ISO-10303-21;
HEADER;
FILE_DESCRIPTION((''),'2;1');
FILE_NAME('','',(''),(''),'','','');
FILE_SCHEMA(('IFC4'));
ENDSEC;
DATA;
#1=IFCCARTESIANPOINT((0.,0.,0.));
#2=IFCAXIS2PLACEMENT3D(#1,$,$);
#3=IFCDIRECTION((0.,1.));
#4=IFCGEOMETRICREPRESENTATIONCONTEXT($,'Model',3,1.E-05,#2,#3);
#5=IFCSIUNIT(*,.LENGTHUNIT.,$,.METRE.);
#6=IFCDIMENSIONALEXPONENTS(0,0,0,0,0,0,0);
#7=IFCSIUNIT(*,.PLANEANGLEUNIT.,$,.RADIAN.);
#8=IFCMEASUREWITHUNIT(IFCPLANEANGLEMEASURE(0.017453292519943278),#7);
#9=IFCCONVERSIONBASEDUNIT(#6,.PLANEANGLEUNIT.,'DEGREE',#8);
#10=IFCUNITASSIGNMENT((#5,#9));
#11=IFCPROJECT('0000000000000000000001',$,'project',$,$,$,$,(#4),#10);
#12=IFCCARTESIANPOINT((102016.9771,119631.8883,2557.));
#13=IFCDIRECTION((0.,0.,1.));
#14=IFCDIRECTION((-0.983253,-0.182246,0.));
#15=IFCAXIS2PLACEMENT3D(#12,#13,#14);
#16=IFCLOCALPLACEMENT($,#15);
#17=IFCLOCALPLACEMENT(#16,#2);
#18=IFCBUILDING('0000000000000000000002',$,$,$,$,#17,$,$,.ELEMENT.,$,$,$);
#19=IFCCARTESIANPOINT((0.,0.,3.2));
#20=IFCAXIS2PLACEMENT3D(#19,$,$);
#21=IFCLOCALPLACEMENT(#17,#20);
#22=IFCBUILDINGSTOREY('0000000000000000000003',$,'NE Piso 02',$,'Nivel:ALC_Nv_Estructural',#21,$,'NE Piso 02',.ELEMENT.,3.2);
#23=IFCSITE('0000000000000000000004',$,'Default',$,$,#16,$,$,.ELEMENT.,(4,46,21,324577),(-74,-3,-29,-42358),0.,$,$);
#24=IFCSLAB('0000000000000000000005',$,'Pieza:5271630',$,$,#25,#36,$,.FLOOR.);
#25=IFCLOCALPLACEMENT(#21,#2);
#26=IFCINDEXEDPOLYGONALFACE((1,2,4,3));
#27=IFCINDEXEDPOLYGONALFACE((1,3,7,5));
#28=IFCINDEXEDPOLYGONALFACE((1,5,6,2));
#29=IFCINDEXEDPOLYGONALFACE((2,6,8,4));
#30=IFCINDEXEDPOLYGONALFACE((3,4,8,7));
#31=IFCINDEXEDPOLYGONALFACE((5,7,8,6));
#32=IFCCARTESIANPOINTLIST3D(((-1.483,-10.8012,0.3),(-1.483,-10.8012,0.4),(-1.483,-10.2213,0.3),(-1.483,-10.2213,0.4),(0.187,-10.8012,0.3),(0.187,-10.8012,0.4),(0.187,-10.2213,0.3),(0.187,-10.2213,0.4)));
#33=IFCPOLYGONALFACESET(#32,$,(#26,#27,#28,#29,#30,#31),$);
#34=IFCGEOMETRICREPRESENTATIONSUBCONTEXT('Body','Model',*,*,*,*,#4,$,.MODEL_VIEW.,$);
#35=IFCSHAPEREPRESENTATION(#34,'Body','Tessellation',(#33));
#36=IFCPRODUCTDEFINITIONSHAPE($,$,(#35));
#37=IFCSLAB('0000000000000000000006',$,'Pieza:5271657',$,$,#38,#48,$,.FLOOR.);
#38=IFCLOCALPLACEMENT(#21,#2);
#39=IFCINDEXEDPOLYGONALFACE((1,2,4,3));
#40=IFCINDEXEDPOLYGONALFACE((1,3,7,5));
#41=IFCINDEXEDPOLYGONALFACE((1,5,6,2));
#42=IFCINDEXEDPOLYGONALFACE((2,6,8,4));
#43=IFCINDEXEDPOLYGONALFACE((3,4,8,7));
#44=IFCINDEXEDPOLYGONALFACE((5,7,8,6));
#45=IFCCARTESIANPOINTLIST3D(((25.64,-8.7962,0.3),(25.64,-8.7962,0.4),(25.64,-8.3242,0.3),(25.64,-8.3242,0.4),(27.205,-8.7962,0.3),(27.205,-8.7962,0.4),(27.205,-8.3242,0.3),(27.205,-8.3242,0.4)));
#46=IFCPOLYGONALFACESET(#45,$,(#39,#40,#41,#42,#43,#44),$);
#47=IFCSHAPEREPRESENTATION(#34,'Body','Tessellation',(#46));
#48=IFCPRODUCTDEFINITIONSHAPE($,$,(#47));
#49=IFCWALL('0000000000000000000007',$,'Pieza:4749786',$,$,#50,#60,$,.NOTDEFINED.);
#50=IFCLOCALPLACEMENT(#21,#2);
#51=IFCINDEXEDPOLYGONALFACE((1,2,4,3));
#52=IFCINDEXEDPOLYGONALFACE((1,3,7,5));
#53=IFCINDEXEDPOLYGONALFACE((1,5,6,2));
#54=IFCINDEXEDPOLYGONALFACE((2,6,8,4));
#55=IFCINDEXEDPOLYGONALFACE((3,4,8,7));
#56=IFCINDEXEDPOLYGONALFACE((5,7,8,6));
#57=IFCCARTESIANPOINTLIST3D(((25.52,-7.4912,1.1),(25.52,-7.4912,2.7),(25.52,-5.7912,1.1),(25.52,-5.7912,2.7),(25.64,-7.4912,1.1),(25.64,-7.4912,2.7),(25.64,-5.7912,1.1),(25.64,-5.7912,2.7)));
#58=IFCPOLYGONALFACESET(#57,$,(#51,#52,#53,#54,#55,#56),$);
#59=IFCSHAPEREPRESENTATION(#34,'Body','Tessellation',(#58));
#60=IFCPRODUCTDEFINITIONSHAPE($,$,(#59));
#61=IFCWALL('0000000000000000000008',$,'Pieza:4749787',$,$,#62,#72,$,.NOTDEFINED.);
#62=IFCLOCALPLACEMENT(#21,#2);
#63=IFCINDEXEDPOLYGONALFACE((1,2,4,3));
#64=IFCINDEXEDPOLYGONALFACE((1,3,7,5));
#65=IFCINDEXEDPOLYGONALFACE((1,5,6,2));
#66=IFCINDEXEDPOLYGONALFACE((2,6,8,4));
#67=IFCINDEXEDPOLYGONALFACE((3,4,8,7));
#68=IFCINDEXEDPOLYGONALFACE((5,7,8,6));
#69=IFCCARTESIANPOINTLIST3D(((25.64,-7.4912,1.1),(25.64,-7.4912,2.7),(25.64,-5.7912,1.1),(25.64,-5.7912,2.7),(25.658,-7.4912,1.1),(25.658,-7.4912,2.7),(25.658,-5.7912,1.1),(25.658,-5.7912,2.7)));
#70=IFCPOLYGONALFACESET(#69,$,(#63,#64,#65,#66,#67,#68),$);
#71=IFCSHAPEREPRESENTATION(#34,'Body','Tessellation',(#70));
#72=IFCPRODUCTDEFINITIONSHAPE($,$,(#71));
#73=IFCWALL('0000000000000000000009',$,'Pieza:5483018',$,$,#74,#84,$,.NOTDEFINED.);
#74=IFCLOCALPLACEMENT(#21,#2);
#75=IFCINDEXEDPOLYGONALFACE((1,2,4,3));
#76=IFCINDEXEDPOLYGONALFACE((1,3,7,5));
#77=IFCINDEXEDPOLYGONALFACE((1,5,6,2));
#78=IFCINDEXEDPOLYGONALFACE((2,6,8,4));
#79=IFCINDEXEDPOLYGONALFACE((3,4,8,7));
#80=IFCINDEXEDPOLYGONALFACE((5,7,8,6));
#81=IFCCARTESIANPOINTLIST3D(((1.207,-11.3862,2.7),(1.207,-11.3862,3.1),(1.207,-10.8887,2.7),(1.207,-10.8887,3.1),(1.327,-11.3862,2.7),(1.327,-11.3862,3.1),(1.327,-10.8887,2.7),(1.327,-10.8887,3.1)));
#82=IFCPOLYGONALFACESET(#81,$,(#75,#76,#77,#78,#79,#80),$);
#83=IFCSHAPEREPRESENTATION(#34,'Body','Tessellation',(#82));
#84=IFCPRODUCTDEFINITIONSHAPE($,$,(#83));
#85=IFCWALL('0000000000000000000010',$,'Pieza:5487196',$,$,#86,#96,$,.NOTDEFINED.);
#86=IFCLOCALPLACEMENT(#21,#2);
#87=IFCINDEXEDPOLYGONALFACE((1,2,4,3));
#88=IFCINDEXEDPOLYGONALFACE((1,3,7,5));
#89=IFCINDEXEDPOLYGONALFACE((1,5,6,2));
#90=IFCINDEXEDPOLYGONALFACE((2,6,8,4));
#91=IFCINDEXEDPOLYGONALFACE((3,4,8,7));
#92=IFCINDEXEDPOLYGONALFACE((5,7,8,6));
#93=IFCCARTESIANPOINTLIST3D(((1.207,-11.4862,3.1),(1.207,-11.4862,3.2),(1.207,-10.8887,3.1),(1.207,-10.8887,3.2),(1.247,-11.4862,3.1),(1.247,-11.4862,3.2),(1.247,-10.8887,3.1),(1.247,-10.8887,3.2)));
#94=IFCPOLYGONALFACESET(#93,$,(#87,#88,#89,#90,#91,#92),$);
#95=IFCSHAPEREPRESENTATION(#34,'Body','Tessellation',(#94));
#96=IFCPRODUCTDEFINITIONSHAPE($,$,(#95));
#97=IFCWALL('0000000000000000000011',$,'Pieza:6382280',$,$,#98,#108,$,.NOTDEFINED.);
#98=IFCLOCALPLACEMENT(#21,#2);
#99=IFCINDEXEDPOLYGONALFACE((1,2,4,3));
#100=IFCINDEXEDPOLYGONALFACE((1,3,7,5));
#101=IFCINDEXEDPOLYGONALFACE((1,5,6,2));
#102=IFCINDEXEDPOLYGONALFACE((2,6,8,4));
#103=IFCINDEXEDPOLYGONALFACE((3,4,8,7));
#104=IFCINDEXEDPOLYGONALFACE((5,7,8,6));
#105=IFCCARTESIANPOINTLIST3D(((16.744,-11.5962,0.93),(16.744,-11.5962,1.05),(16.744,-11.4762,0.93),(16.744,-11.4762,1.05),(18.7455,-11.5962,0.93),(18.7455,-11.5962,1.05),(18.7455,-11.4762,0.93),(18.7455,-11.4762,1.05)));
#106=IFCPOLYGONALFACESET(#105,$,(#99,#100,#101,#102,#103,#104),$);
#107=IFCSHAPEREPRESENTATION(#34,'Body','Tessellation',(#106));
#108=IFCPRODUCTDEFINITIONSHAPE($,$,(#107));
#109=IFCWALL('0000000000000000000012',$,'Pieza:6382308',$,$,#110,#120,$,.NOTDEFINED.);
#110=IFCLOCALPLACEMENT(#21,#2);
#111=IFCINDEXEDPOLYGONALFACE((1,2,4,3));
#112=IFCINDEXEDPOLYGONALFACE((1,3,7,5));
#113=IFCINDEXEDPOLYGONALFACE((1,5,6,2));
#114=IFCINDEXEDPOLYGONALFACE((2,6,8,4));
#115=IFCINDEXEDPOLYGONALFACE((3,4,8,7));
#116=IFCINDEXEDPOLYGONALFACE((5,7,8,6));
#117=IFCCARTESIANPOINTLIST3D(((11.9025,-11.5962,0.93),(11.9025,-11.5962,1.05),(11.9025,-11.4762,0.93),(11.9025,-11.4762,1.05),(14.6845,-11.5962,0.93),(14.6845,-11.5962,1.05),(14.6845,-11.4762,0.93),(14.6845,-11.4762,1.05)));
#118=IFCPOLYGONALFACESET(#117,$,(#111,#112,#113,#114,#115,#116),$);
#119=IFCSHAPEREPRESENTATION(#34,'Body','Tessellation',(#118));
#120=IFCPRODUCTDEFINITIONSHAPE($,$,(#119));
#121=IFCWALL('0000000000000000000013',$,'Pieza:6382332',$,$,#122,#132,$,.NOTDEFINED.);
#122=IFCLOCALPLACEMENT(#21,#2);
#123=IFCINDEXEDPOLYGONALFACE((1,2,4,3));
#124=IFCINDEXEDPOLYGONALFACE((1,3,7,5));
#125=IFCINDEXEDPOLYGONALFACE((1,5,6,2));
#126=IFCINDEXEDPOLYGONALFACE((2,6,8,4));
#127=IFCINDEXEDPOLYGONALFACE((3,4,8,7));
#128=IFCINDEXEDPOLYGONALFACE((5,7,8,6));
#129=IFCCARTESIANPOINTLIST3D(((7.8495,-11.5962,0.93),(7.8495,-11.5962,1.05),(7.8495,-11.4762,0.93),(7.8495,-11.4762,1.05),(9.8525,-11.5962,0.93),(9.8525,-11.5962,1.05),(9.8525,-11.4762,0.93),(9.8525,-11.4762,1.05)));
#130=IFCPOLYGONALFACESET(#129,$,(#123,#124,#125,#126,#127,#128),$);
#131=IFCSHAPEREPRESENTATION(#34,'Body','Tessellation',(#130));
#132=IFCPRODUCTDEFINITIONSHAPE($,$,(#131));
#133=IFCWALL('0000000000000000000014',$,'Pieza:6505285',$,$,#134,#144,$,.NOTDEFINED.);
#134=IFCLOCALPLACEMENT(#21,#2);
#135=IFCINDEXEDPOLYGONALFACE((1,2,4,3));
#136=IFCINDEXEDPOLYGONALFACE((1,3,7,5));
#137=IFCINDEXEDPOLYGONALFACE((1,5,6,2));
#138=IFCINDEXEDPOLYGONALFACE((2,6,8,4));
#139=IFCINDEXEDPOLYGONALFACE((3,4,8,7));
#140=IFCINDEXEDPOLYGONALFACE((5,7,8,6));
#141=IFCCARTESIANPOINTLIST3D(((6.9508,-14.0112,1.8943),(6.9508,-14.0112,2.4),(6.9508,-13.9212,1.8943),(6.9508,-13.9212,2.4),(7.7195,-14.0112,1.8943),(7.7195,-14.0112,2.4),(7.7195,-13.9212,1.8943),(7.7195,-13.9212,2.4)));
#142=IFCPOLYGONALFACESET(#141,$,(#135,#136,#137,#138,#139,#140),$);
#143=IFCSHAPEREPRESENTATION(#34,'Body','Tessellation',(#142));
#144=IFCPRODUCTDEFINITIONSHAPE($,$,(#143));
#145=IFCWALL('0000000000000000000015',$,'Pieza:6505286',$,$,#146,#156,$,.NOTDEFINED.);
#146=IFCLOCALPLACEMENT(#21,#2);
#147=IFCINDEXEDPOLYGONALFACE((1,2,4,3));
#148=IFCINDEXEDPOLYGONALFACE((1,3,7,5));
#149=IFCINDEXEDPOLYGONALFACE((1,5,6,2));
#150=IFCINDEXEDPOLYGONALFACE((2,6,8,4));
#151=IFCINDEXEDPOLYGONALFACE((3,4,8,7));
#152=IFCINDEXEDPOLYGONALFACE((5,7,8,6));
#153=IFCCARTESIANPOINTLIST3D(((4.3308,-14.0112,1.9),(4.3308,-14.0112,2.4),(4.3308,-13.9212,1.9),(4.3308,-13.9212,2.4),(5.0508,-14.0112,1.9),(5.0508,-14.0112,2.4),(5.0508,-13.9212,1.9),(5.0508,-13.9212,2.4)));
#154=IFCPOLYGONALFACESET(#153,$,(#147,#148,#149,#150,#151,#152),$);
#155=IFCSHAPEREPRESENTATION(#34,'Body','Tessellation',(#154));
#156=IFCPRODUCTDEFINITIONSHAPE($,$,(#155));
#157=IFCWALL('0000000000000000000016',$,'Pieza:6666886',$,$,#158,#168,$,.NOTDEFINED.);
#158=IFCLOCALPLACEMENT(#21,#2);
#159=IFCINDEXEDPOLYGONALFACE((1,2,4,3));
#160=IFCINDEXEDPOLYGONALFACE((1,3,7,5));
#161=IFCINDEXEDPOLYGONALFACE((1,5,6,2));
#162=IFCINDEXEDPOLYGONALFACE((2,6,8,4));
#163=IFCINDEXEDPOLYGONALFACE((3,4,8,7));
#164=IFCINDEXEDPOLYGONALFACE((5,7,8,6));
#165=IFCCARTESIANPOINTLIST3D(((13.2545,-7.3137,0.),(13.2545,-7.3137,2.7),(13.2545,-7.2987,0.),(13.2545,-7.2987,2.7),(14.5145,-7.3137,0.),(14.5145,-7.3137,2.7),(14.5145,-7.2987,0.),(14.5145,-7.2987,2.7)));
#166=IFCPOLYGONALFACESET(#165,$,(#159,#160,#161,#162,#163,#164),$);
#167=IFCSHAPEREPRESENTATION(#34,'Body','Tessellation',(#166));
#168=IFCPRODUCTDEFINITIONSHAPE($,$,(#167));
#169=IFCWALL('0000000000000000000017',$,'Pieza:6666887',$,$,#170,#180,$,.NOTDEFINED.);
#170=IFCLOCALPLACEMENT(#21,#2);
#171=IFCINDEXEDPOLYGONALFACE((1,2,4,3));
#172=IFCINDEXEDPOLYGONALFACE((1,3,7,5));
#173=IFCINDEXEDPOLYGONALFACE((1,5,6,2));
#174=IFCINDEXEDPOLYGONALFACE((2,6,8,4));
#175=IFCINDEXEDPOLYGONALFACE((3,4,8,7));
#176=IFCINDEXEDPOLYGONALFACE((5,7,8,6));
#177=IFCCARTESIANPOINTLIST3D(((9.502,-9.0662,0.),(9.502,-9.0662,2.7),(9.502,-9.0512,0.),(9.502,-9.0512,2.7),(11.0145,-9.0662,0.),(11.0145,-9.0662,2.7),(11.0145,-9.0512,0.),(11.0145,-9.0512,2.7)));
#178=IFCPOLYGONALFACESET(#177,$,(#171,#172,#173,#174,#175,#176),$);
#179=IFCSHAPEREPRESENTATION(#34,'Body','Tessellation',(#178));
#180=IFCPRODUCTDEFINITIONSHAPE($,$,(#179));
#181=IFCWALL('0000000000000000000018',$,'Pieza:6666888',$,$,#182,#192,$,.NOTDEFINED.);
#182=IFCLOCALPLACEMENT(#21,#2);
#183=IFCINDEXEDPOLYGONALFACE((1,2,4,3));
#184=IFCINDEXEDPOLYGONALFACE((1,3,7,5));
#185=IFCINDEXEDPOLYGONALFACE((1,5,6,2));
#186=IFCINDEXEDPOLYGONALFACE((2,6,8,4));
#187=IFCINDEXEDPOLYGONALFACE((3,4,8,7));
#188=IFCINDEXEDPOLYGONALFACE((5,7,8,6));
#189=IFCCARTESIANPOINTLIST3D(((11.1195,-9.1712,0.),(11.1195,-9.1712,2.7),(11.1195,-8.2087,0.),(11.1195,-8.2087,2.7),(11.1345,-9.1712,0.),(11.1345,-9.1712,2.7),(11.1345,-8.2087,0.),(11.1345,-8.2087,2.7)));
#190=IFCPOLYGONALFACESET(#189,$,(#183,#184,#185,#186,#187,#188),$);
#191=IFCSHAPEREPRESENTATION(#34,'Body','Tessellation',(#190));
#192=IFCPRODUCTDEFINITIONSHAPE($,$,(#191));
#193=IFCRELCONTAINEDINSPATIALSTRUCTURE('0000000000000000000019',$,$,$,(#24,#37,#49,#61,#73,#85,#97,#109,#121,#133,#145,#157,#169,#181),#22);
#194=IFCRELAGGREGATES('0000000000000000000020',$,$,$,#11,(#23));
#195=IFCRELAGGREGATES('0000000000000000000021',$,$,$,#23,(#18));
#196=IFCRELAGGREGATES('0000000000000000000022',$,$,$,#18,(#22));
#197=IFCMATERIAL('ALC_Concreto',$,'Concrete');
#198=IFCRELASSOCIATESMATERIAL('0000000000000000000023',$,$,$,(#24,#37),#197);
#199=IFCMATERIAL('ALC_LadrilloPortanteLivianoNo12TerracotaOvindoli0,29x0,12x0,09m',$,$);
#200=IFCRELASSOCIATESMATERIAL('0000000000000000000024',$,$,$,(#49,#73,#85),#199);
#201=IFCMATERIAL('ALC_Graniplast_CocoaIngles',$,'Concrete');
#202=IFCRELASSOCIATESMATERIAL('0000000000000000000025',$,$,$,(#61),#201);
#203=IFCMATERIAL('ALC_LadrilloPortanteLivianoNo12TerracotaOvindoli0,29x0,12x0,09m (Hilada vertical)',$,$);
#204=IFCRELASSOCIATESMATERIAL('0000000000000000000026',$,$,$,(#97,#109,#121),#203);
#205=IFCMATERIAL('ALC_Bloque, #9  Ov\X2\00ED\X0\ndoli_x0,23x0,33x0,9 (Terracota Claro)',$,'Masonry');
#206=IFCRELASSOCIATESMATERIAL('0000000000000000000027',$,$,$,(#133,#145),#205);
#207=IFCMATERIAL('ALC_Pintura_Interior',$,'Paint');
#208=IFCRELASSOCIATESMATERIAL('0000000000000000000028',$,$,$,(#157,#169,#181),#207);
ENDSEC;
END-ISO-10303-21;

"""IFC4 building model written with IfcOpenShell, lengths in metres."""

from ifc_helpers import new_model, entity, si_unit, converted_unit, direction, frame, frame_2d, origin, origin_2d_with_axis, place, context, subcontext, project, spatial, rectangle, extrude, material, element, save


model = new_model("IFC4")

# Units and contexts
model_context = context("Model", 3, precision=1e-05, world=origin(), true_north=direction((0.0, 1.0)))
body_context = subcontext(model_context, "Body", "Model", "MODEL_VIEW")
ifc_project = project(units=[si_unit("LENGTHUNIT", "METRE"), converted_unit("PLANEANGLEUNIT", "DEGREE", entity("IfcPlaneAngleMeasure", 0.017453292519943278), si_unit("PLANEANGLEUNIT", "RADIAN"), dimensions=[0, 0, 0, 0, 0, 0, 0])], contexts=[model_context])

# Site, building, storey
site_placement = place(None, frame((102016.9771, 119631.8883, 2557.0), z_axis=(0.0, 0.0, 1.0), x_axis=(-0.983253, -0.182246, 0.0)))
site = spatial("IfcSite", under=ifc_project, at=site_placement, Name="Default", CompositionType="ELEMENT", RefLatitude=(4, 46, 21, 324577), RefLongitude=(-74, -3, -29, -42358), RefElevation=0.0)
building_placement = place(site_placement, origin())
building = spatial("IfcBuilding", under=site, at=building_placement, CompositionType="ELEMENT")
storey_placement = place(building_placement, frame((0.0, 0.0, 3.2)))
storey = spatial("IfcBuildingStorey", under=building, at=storey_placement, Name="NE Piso 02", ObjectType="Nivel:ALC_Nv_Estructural", LongName="NE Piso 02", CompositionType="ELEMENT", Elevation=3.2)

# Slabs
ifc_material_1 = material(Name="ALC_Concreto", Category="Concrete")
slab_1_placement = place(storey_placement, frame((0.0, 0.0, 0.3)))
element("IfcSlab", 1, at=slab_1_placement, inside=storey, material=ifc_material_1, Name="Pieza:5271630", PredefinedType="FLOOR", context=body_context, shape_type="SweptSolid", body=[
    extrude(rectangle(XDim=0.5799, YDim=1.67, at=frame_2d((0.0, 0.0), x_axis=(1.0, 0.0))), frame((-0.648, -10.5112, 0.0), z_axis=(0.0, 0.0, 1.0), x_axis=(0.0, -1.0, 0.0)), (0.0, 0.0, 1.0), 0.1),
])
slab_2_placement = place(storey_placement, frame((0.0, 0.0, 0.3)))
element("IfcSlab", 2, at=slab_2_placement, inside=storey, material=ifc_material_1, Name="Pieza:5271657", PredefinedType="FLOOR", context=body_context, shape_type="SweptSolid", body=[
    extrude(rectangle(XDim=0.472, YDim=1.565, at=frame_2d((0.0, 0.0), x_axis=(1.0, 0.0))), frame((26.4225, -8.5602, 0.0), z_axis=(0.0, 0.0, 1.0), x_axis=(0.0, -1.0, 0.0)), (0.0, 0.0, 1.0), 0.1),
])

# Walls
ifc_material_2 = material(Name="ALC_LadrilloPortanteLivianoNo12TerracotaOvindoli0,29x0,12x0,09m")
wall_1_placement = place(storey_placement, frame((0.0, 0.0, 1.1)))
element("IfcWall", 3, at=wall_1_placement, inside=storey, material=ifc_material_2, Name="Pieza:4749786", PredefinedType="NOTDEFINED", context=body_context, shape_type="SweptSolid", body=[
    extrude(rectangle(XDim=1.7, YDim=0.12, at=origin_2d_with_axis()), frame((25.58, -6.6412, 0.0), z_axis=(0.0, 0.0, 1.0), x_axis=(0.0, -1.0, 0.0)), (0.0, 0.0, 1.0), 1.6),
])
ifc_material_3 = material(Name="ALC_Graniplast_CocoaIngles", Category="Concrete")
wall_2_placement = place(storey_placement, frame((0.0, 0.0, 1.1)))
element("IfcWall", 4, at=wall_2_placement, inside=storey, material=ifc_material_3, Name="Pieza:4749787", PredefinedType="NOTDEFINED", context=body_context, shape_type="SweptSolid", body=[
    extrude(rectangle(XDim=1.7, YDim=0.018, at=frame_2d((0.0, 0.0), x_axis=(1.0, 0.0))), frame((25.649, -6.6412, 0.0), z_axis=(0.0, 0.0, 1.0), x_axis=(0.0, -1.0, 0.0)), (0.0, 0.0, 1.0), 1.6),
])
wall_3_placement = place(storey_placement, frame((0.0, 0.0, 2.7)))
element("IfcWall", 5, at=wall_3_placement, inside=storey, material=ifc_material_2, Name="Pieza:5483018", PredefinedType="NOTDEFINED", context=body_context, shape_type="SweptSolid", body=[
    extrude(rectangle(XDim=0.4975, YDim=0.12, at=frame_2d((0.0, 0.0), x_axis=(1.0, 0.0))), frame((1.267, -11.1374, 0.0), z_axis=(0.0, 0.0, 1.0), x_axis=(0.0, -1.0, 0.0)), (0.0, 0.0, 1.0), 0.4),
])
wall_4_placement = place(storey_placement, frame((0.0, 0.0, 3.1)))
element("IfcWall", 6, at=wall_4_placement, inside=storey, material=ifc_material_2, Name="Pieza:5487196", PredefinedType="NOTDEFINED", context=body_context, shape_type="SweptSolid", body=[
    extrude(rectangle(XDim=0.5975, YDim=0.04, at=frame_2d((0.0, 0.0), x_axis=(1.0, 0.0))), frame((1.227, -11.1874, 0.0), z_axis=(0.0, 0.0, 1.0), x_axis=(0.0, -1.0, 0.0)), (0.0, 0.0, 1.0), 0.1),
])
ifc_material_4 = material(Name="ALC_LadrilloPortanteLivianoNo12TerracotaOvindoli0,29x0,12x0,09m (Hilada vertical)")
wall_5_placement = place(storey_placement, frame((0.0, 0.0, 0.93)))
element("IfcWall", 7, at=wall_5_placement, inside=storey, material=ifc_material_4, Name="Pieza:6382280", PredefinedType="NOTDEFINED", context=body_context, shape_type="SweptSolid", body=[
    extrude(rectangle(XDim=0.12, YDim=2.0015, at=origin_2d_with_axis()), frame((17.7448, -11.5362, 0.0), z_axis=(0.0, 0.0, 1.0), x_axis=(0.0, -1.0, 0.0)), (0.0, 0.0, 1.0), 0.12),
])
wall_6_placement = place(storey_placement, frame((0.0, 0.0, 0.93)))
element("IfcWall", 8, at=wall_6_placement, inside=storey, material=ifc_material_4, Name="Pieza:6382308", PredefinedType="NOTDEFINED", context=body_context, shape_type="SweptSolid", body=[
    extrude(rectangle(XDim=0.12, YDim=2.782, at=origin_2d_with_axis()), frame((13.2935, -11.5362, 0.0), z_axis=(0.0, 0.0, 1.0), x_axis=(0.0, -1.0, 0.0)), (0.0, 0.0, 1.0), 0.12),
])
wall_7_placement = place(storey_placement, frame((0.0, 0.0, 0.93)))
element("IfcWall", 9, at=wall_7_placement, inside=storey, material=ifc_material_4, Name="Pieza:6382332", PredefinedType="NOTDEFINED", context=body_context, shape_type="SweptSolid", body=[
    extrude(rectangle(XDim=0.12, YDim=2.003, at=origin_2d_with_axis()), frame((8.851, -11.5362, 0.0), z_axis=(0.0, 0.0, 1.0), x_axis=(0.0, -1.0, 0.0)), (0.0, 0.0, 1.0), 0.12),
])
ifc_material_5 = material(Name="ALC_Bloque, #9  Ovíndoli_x0,23x0,33x0,9 (Terracota Claro)", Category="Masonry")
wall_8_placement = place(storey_placement, frame((0.0, 0.0, 1.8943)))
element("IfcWall", 10, at=wall_8_placement, inside=storey, material=ifc_material_5, Name="Pieza:6505285", PredefinedType="NOTDEFINED", context=body_context, shape_type="SweptSolid", body=[
    extrude(rectangle(XDim=0.09, YDim=0.7688, at=frame_2d((0.0, 0.0), x_axis=(1.0, 0.0))), frame((7.3352, -13.9662, 0.0), z_axis=(0.0, 0.0, 1.0), x_axis=(0.0, -1.0, 0.0)), (0.0, 0.0, 1.0), 0.5057),
])
wall_9_placement = place(storey_placement, frame((0.0, 0.0, 1.9)))
element("IfcWall", 11, at=wall_9_placement, inside=storey, material=ifc_material_5, Name="Pieza:6505286", PredefinedType="NOTDEFINED", context=body_context, shape_type="SweptSolid", body=[
    extrude(rectangle(XDim=0.09, YDim=0.72, at=frame_2d((0.0, 0.0), x_axis=(1.0, 0.0))), frame((4.6908, -13.9662, 0.0), z_axis=(0.0, 0.0, 1.0), x_axis=(0.0, -1.0, 0.0)), (0.0, 0.0, 1.0), 0.5),
])
ifc_material_6 = material(Name="ALC_Pintura_Interior", Category="Paint")
wall_10_placement = place(storey_placement, origin())
element("IfcWall", 12, at=wall_10_placement, inside=storey, material=ifc_material_6, Name="Pieza:6666886", PredefinedType="NOTDEFINED", context=body_context, shape_type="SweptSolid", body=[
    extrude(rectangle(XDim=0.015, YDim=1.26, at=origin_2d_with_axis()), frame((13.8845, -7.3062, 0.0), z_axis=(0.0, 0.0, 1.0), x_axis=(0.0, -1.0, 0.0)), (0.0, 0.0, 1.0), 2.7),
])
wall_11_placement = place(storey_placement, origin())
element("IfcWall", 13, at=wall_11_placement, inside=storey, material=ifc_material_6, Name="Pieza:6666887", PredefinedType="NOTDEFINED", context=body_context, shape_type="SweptSolid", body=[
    extrude(rectangle(XDim=0.015, YDim=1.5125, at=frame_2d((0.0, 0.0), x_axis=(1.0, 0.0))), frame((10.2583, -9.0587, 0.0), z_axis=(0.0, 0.0, 1.0), x_axis=(0.0, -1.0, 0.0)), (0.0, 0.0, 1.0), 2.7),
])
wall_12_placement = place(storey_placement, origin())
element("IfcWall", 14, at=wall_12_placement, inside=storey, material=ifc_material_6, Name="Pieza:6666888", PredefinedType="NOTDEFINED", context=body_context, shape_type="SweptSolid", body=[
    extrude(rectangle(XDim=0.9625, YDim=0.015, at=frame_2d((0.0, 0.0), x_axis=(1.0, 0.0))), frame((11.127, -8.6899, 0.0), z_axis=(0.0, 0.0, 1.0), x_axis=(0.0, -1.0, 0.0)), (0.0, 0.0, 1.0), 2.7),
])

save(model, "model.ifc")
